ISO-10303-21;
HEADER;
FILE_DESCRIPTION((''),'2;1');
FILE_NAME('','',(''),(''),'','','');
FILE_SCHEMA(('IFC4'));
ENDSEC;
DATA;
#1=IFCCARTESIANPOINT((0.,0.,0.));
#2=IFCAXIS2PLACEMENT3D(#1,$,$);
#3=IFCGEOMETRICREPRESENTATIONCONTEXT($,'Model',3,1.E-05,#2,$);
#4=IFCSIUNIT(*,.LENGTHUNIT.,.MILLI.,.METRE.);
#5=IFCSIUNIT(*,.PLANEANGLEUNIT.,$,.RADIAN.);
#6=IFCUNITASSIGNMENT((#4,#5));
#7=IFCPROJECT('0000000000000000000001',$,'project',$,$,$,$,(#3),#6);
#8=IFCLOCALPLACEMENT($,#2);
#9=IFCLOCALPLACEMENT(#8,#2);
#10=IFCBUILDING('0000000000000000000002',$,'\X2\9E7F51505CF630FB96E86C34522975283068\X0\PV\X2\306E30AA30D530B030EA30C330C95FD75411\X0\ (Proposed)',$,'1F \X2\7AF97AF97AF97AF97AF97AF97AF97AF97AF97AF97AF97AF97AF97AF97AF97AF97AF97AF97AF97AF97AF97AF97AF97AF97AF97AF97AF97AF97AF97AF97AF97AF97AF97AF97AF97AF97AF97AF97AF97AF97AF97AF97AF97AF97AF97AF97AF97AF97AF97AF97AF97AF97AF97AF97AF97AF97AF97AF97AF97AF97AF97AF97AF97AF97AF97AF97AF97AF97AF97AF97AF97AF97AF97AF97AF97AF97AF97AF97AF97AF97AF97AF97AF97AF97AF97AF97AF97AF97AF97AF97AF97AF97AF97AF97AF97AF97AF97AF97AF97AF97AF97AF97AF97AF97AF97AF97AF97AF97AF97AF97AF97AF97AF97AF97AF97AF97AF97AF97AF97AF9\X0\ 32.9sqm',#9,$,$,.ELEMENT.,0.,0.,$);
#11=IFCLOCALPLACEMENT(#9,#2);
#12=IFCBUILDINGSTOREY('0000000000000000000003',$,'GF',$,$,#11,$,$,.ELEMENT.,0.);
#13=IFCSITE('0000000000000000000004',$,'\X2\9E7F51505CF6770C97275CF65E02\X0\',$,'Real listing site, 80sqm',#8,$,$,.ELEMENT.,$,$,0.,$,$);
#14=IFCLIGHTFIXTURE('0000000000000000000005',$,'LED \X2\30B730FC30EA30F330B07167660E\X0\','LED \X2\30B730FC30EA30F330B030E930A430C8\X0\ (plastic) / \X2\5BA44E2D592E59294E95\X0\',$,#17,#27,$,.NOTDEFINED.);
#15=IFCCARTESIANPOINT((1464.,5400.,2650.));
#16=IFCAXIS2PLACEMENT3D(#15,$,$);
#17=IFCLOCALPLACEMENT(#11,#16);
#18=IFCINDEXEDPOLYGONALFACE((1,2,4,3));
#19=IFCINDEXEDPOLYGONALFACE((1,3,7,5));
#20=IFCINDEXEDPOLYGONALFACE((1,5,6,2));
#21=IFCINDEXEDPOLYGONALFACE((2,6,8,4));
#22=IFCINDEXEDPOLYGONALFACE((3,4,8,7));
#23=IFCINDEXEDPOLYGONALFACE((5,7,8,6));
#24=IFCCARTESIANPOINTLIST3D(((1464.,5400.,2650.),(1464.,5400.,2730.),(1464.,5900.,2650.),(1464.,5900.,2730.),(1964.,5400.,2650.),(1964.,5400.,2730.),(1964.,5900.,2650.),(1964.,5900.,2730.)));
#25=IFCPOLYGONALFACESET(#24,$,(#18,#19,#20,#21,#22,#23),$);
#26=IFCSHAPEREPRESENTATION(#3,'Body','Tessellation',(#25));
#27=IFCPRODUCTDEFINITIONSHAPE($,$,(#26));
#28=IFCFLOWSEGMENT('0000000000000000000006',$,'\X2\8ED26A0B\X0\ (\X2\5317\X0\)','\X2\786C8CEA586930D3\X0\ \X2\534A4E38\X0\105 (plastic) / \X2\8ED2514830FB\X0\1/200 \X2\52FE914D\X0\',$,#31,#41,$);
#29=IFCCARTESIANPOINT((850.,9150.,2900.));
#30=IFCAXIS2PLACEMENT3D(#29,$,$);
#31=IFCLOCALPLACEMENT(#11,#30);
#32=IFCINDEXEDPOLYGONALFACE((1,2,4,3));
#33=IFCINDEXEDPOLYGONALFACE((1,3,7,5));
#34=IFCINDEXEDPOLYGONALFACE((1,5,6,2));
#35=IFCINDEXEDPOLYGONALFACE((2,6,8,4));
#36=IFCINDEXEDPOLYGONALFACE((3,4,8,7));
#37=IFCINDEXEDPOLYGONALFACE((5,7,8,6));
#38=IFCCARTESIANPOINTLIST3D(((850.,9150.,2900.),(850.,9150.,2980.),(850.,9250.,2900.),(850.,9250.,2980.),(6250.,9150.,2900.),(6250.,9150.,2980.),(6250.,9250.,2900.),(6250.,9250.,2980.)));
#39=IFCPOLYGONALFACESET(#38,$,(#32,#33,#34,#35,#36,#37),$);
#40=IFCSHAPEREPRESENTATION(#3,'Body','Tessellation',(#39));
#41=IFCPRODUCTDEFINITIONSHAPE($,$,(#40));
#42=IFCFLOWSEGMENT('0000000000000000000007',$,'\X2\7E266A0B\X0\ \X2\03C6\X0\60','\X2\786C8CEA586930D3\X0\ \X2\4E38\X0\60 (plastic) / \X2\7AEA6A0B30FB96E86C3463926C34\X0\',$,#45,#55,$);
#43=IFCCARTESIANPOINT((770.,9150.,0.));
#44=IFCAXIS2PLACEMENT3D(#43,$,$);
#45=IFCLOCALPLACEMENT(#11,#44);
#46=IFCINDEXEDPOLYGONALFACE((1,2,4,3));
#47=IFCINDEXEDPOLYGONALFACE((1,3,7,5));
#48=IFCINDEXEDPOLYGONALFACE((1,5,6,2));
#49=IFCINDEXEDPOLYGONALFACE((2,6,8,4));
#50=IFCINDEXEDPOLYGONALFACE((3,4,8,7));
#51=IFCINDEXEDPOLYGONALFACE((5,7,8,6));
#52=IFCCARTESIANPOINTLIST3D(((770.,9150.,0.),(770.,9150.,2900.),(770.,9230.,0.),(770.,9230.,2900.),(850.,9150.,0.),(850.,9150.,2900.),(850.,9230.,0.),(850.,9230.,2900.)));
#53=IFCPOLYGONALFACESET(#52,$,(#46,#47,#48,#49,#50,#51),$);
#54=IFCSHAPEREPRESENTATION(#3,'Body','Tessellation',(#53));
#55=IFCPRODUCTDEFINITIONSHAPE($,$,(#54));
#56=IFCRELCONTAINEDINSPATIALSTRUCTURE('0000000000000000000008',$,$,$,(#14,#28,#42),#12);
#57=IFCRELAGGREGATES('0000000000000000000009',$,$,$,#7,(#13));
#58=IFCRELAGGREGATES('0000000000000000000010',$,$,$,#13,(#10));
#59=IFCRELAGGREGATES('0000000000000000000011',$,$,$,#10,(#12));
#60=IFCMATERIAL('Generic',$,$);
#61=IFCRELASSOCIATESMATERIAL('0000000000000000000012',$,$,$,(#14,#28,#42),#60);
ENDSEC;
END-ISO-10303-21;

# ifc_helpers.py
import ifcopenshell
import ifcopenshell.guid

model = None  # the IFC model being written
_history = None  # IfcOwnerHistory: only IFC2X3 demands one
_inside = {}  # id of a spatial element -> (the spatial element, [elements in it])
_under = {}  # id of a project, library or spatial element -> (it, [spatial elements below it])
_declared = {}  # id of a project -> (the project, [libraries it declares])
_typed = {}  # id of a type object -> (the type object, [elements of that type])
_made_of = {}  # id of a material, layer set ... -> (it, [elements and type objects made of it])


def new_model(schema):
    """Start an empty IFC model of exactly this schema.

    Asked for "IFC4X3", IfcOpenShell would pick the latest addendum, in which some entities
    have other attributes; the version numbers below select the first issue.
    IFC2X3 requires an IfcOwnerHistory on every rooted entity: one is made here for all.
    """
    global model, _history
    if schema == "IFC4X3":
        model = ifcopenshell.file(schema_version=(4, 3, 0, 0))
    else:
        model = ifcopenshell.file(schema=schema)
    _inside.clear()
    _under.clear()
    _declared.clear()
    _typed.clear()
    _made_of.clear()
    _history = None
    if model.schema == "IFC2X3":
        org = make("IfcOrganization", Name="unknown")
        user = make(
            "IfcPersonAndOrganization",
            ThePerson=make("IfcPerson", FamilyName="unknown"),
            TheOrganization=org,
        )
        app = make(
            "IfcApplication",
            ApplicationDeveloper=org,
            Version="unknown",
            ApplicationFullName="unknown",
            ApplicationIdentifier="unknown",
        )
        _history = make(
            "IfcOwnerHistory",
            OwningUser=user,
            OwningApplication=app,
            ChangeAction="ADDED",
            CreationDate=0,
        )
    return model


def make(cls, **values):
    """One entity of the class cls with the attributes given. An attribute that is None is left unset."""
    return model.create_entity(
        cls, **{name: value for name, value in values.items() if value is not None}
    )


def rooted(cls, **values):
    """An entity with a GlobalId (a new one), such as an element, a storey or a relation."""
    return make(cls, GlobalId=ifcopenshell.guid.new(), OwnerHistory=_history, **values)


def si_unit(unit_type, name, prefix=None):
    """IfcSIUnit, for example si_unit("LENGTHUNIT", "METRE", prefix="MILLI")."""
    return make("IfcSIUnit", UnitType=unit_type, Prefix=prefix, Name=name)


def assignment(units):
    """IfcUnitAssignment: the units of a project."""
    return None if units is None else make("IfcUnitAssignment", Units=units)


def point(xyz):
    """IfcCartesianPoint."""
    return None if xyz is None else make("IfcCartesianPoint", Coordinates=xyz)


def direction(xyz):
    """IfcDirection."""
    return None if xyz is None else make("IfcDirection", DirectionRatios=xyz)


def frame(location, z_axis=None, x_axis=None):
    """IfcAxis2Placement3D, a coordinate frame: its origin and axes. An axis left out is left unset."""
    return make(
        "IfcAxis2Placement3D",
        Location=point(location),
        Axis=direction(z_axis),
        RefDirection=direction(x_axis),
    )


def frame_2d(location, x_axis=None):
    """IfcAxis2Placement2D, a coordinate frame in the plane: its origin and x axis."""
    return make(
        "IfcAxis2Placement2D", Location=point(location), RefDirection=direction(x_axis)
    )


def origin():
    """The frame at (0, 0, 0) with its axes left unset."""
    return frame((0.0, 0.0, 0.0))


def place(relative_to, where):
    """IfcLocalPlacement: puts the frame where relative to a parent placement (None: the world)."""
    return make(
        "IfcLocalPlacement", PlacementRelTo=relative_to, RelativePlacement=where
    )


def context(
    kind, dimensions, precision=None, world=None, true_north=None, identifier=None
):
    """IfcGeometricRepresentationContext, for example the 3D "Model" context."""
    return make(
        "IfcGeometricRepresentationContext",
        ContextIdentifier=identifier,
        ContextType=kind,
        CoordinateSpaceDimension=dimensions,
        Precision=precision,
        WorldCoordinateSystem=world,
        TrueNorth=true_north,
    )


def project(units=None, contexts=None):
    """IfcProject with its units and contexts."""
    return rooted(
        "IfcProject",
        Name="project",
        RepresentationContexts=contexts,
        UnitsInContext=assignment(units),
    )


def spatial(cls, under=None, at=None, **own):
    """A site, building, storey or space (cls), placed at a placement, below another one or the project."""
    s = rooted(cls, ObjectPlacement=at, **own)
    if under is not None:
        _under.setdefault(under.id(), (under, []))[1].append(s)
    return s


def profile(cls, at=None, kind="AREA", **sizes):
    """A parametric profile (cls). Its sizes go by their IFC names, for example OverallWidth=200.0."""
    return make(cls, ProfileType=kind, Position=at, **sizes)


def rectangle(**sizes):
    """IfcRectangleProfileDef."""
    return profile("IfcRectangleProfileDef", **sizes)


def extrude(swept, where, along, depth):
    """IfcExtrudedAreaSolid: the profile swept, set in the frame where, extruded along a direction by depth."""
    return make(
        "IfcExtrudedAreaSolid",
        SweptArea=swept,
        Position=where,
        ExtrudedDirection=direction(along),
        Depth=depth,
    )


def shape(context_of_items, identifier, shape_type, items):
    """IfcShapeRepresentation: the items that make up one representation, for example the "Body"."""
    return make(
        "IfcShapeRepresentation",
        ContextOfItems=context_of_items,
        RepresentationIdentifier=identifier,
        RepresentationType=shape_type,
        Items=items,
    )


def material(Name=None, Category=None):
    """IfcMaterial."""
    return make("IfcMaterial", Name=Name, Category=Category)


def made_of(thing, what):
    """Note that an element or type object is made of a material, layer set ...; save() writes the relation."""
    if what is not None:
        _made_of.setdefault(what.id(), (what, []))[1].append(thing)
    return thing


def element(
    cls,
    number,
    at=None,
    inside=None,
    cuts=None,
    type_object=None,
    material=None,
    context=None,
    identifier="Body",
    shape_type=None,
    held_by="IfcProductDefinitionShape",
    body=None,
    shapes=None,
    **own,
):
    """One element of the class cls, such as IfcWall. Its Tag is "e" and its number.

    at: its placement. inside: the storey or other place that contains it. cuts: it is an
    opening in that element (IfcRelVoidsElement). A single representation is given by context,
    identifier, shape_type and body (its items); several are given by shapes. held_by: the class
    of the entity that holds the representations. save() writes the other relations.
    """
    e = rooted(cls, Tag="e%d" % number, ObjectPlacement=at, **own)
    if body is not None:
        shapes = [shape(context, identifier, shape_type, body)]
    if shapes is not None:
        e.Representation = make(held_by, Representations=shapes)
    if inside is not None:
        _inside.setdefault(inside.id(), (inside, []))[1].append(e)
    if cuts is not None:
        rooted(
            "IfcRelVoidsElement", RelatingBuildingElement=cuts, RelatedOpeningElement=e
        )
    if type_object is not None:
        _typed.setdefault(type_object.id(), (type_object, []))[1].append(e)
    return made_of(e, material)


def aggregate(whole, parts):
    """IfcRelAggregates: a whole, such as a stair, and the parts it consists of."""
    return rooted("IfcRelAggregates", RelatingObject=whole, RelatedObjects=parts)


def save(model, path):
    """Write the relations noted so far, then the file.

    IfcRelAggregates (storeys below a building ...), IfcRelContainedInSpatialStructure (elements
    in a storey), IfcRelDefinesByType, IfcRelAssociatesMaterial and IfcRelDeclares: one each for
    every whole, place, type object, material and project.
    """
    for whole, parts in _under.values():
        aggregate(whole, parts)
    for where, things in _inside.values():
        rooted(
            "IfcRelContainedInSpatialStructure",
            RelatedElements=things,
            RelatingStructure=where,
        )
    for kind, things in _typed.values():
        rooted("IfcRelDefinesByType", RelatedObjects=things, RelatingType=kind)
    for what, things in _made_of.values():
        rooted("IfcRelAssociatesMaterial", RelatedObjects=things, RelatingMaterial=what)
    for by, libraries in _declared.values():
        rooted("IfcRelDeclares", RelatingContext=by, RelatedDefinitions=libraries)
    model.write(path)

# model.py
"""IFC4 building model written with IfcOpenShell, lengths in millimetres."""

from ifc_helpers import new_model, si_unit, frame, frame_2d, origin, place, context, project, spatial, rectangle, extrude, material, element, save


model = new_model("IFC4")

# Units and contexts
model_context = context("Model", 3, precision=1e-05, world=origin())
ifc_project = project(units=[si_unit("LENGTHUNIT", "METRE", prefix="MILLI"), si_unit("PLANEANGLEUNIT", "RADIAN")], contexts=[model_context])

# Site, building, storey
site_placement = place(None, origin())
site = spatial("IfcSite", under=ifc_project, at=site_placement, Name="鹿児島県霧島市", ObjectType="Real listing site, 80sqm", CompositionType="ELEMENT", RefElevation=0.0)
building_placement = place(site_placement, origin())
building = spatial("IfcBuilding", under=site, at=building_placement, Name="鹿児島・雨水利用とPVのオフグリッド志向 (Proposed)", ObjectType="1F 竹竹竹竹竹竹竹竹竹竹竹竹竹竹竹竹竹竹竹竹竹竹竹竹竹竹竹竹竹竹竹竹竹竹竹竹竹竹竹竹竹竹竹竹竹竹竹竹竹竹竹竹竹竹竹竹竹竹竹竹竹竹竹竹竹竹竹竹竹竹竹竹竹竹竹竹竹竹竹竹竹竹竹竹竹竹竹竹竹竹竹竹竹竹竹竹竹竹竹竹竹竹竹竹竹竹竹竹竹竹竹竹竹竹竹竹竹竹竹竹 32.9sqm", CompositionType="ELEMENT", ElevationOfRefHeight=0.0, ElevationOfTerrain=0.0)
storey_placement = place(building_placement, origin())
storey = spatial("IfcBuildingStorey", under=building, at=storey_placement, Name="GF", CompositionType="ELEMENT", Elevation=0.0)

# Shared definitions
ifc_material_1 = material(Name="Generic")

# Light fixture
light_fixture_placement = place(storey_placement, frame((1464.0, 5400.0, 2650.0)))
element("IfcLightFixture", 1, at=light_fixture_placement, inside=storey, material=ifc_material_1, Name="LED シーリング照明", Description="LED シーリングライト (plastic) / 室中央天井", PredefinedType="NOTDEFINED", context=model_context, shape_type="SweptSolid", body=[
    extrude(rectangle(XDim=500.0, YDim=500.0, at=frame_2d((250.0, 250.0))), frame((1464.0, 5400.0, 2650.0)), (0.0, 0.0, 1.0), 80.0),
])

# Flow segments
flow_segment_1_placement = place(storey_placement, frame((850.0, 9150.0, 2900.0)))
element("IfcFlowSegment", 2, at=flow_segment_1_placement, inside=storey, material=ifc_material_1, Name="軒樋 (北)", Description="硬質塩ビ 半丸105 (plastic) / 軒先・1/200 勾配", context=model_context, shape_type="SweptSolid", body=[
    extrude(rectangle(XDim=5400.0, YDim=100.0, at=frame_2d((2700.0, 50.0))), frame((850.0, 9150.0, 2900.0)), (0.0, 0.0, 1.0), 80.0),
])
flow_segment_2_placement = place(storey_placement, frame((770.0, 9150.0, 0.0)))
element("IfcFlowSegment", 3, at=flow_segment_2_placement, inside=storey, material=ifc_material_1, Name="縦樋 φ60", Description="硬質塩ビ 丸60 (plastic) / 竪樋・雨水排水", context=model_context, shape_type="SweptSolid", body=[
    extrude(rectangle(XDim=80.0, YDim=80.0, at=frame_2d((40.0, 40.0))), frame((770.0, 9150.0, 0.0)), (0.0, 0.0, 1.0), 2900.0),
])

save(model, "model.ifc")
